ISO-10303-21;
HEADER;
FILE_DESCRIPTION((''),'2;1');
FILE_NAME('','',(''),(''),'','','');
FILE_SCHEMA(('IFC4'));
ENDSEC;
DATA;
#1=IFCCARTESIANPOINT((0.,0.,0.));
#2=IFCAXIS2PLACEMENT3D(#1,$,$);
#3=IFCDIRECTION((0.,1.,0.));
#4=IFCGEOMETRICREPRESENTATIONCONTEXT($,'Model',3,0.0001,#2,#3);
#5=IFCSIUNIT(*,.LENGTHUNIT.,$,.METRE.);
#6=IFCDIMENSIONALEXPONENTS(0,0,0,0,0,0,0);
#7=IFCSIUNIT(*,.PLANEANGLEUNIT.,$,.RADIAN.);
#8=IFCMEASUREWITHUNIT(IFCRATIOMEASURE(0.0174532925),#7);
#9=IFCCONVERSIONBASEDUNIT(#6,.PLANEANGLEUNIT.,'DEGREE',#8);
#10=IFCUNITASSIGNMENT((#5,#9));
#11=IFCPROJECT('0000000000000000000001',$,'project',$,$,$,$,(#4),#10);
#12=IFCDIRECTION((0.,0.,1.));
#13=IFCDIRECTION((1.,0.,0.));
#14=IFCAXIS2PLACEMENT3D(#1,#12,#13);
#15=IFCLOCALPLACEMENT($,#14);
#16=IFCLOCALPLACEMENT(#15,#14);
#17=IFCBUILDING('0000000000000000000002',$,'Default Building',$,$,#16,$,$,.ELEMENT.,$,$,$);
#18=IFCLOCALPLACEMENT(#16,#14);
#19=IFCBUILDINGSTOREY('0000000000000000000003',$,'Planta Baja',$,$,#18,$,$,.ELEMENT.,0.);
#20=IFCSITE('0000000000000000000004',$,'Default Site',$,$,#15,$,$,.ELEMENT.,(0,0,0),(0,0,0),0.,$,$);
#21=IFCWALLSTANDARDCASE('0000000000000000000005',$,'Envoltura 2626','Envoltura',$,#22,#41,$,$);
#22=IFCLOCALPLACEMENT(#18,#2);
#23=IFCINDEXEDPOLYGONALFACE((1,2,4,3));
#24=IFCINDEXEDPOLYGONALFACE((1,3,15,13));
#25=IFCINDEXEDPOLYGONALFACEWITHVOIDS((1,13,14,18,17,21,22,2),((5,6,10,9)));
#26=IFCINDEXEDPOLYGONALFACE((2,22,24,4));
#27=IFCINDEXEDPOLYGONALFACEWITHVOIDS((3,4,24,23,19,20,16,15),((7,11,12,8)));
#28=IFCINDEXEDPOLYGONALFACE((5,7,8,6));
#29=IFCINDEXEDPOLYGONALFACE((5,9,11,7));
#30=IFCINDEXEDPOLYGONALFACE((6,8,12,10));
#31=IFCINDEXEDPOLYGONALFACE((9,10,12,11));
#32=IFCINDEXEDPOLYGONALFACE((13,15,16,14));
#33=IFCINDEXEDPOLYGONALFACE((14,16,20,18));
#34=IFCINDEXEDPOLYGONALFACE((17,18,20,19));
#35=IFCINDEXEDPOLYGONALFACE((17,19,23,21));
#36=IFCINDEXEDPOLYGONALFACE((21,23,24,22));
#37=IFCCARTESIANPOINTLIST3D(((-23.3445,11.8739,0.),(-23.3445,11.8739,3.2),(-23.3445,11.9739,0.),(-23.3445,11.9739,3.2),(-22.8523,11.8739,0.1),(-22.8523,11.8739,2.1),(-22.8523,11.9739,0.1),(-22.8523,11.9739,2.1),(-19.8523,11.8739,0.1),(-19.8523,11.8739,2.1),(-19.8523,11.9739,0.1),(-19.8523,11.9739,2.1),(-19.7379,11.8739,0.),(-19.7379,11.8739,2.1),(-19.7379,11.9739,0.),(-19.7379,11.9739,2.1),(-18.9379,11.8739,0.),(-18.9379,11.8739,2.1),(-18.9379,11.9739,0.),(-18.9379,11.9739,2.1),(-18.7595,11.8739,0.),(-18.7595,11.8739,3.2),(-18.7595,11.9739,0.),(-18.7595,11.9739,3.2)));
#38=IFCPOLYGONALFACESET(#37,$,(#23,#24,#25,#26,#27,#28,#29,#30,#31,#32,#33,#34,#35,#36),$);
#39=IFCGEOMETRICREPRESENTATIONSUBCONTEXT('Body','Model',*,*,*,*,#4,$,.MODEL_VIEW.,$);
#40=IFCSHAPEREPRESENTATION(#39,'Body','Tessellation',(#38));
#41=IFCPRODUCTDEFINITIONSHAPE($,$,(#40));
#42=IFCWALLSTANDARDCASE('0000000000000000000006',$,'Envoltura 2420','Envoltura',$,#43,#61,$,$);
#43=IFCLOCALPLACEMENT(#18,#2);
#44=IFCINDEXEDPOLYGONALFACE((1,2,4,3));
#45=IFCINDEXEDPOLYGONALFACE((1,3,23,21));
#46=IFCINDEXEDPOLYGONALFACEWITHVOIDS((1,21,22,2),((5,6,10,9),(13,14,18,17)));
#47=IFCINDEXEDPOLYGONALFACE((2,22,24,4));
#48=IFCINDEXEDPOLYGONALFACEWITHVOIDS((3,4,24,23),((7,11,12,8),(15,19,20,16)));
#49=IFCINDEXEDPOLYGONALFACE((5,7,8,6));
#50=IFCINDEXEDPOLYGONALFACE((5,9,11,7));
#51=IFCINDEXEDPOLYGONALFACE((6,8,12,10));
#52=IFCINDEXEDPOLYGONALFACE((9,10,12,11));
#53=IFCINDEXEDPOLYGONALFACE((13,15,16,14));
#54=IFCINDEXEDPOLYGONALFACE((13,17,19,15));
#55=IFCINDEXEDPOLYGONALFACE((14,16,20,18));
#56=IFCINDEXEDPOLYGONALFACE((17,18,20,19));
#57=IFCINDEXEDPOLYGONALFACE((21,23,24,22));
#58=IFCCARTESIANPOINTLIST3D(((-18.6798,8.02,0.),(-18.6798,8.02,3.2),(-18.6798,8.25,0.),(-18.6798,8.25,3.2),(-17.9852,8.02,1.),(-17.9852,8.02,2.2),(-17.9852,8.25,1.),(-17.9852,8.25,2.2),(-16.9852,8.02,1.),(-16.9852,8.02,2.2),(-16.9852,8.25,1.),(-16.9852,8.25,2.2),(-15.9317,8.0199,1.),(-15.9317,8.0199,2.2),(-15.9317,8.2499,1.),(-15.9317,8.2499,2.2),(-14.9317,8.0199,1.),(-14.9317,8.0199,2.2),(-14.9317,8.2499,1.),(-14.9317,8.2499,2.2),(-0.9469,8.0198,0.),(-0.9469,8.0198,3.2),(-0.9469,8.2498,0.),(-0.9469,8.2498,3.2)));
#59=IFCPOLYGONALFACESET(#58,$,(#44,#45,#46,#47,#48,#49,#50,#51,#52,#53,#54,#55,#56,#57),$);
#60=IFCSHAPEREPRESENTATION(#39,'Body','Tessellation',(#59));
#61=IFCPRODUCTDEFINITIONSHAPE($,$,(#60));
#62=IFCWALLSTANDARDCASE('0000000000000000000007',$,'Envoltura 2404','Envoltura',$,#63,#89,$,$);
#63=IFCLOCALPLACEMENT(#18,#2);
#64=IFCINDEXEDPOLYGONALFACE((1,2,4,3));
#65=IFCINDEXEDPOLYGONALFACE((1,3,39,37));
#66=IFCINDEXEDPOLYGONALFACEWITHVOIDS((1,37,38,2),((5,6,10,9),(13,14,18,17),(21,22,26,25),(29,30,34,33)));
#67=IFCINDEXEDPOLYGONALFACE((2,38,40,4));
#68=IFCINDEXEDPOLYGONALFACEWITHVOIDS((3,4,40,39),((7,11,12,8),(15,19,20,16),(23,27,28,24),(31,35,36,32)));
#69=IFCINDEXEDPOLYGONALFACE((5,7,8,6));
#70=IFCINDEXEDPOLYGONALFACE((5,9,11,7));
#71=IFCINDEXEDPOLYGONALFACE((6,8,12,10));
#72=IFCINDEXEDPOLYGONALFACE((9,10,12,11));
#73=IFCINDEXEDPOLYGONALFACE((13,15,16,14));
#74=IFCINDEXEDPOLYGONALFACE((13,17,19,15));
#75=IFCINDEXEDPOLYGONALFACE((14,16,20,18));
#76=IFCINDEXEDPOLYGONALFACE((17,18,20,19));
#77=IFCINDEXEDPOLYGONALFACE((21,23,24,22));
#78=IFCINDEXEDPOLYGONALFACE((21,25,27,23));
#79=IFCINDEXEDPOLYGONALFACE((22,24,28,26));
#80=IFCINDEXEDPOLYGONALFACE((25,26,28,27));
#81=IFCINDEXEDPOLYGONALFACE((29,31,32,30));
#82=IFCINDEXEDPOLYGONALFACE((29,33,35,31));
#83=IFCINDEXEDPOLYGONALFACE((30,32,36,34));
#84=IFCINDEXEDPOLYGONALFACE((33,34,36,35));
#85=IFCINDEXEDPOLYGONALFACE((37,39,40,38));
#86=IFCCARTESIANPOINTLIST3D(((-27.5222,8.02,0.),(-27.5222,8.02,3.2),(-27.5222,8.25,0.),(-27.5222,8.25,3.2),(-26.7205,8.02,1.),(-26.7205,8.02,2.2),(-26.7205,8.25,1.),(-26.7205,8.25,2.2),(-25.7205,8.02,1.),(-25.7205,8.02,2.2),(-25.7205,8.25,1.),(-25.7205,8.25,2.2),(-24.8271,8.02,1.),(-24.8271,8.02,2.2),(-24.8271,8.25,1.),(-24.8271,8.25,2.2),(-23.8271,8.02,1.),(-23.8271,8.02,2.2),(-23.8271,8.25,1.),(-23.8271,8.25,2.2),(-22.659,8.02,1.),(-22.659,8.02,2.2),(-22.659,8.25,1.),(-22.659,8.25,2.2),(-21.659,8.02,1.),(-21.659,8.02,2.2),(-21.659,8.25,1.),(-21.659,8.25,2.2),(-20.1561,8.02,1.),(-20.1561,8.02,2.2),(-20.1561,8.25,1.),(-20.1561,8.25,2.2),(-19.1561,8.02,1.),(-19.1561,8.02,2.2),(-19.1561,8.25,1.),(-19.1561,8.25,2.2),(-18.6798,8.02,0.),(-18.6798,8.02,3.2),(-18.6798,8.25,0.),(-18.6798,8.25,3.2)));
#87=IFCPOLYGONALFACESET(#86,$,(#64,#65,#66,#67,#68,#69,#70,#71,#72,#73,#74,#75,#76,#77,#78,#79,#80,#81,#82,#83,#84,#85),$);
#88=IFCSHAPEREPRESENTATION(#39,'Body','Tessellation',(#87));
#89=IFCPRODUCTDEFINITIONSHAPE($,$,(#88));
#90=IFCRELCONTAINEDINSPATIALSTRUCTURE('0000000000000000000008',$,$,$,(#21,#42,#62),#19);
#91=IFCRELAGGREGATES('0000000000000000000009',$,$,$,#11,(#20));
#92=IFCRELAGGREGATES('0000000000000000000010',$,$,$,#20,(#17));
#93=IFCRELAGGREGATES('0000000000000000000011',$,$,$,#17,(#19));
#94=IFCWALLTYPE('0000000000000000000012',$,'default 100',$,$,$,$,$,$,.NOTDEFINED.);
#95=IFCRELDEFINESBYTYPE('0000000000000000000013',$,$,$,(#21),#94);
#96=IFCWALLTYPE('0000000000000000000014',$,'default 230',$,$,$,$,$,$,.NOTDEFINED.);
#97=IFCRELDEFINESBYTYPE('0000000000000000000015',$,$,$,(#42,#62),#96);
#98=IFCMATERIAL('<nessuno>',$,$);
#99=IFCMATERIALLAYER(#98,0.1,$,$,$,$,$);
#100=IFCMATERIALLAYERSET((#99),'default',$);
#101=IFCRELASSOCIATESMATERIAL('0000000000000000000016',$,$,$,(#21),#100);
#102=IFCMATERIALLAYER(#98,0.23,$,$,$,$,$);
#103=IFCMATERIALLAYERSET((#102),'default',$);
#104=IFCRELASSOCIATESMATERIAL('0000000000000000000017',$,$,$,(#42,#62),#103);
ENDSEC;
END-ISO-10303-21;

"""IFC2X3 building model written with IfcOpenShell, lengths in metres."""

from ifc_helpers import new_model, entity, si_unit, converted_unit, direction, frame, origin, origin_with_axes, origin_2d_with_axis, place, context, subcontext, project, spatial, polyline, rectangle, outline, extrude, material, layer, layer_set, layer_usage, type_object, element, save


model = new_model("IFC2X3")

# Units and contexts
model_context = context("Model", 3, precision=0.0001, world=origin(), true_north=direction((0.0, 1.0, 0.0)))
body_context = subcontext(model_context, "Body", "Model", "MODEL_VIEW")
ifc_project = project(units=[si_unit("LENGTHUNIT", "METRE"), converted_unit("PLANEANGLEUNIT", "DEGREE", entity("IfcRatioMeasure", 0.0174532925), si_unit("PLANEANGLEUNIT", "RADIAN"), dimensions=[0, 0, 0, 0, 0, 0, 0])], contexts=[model_context])

# Site, building, storey
site_placement = place(None, origin_with_axes())
site = spatial("IfcSite", under=ifc_project, at=site_placement, Name="Default Site", CompositionType="ELEMENT", RefLatitude=(0, 0, 0), RefLongitude=(0, 0, 0), RefElevation=0.0)
building_placement = place(site_placement, origin_with_axes())
building = spatial("IfcBuilding", under=site, at=building_placement, Name="Default Building", CompositionType="ELEMENT")
storey_placement = place(building_placement, origin_with_axes())
storey = spatial("IfcBuildingStorey", under=building, at=storey_placement, Name="Planta Baja", CompositionType="ELEMENT", Elevation=0.0)

# Shared definitions
ifc_material_1 = material(Name="<nessuno>")

# Shared definitions
ifc_layer_1 = layer(ifc_material_1, 0.1)
ifc_layer_set_1 = layer_set([ifc_layer_1], Name="default")
wall_type_1 = type_object("IfcWallType", Name="default 100", PredefinedType="NOTDEFINED")

# Wall, openings
ifc_layer_usage_1 = layer_usage(ifc_layer_set_1, "AXIS2", "POSITIVE", -0.05)
wall_1_placement = place(storey_placement, frame((-23.3645, 11.9239, 0.0), z_axis=(0.0, 0.0, 1.0), x_axis=(1.0, 0.0, 0.0)))
wall_1 = element("IfcWallStandardCase", 1, at=wall_1_placement, inside=storey, type_object=wall_type_1, material=ifc_layer_usage_1, Name="Envoltura 2626", Description="Envoltura", context=body_context, shape_type="SweptSolid", body=[
    extrude(rectangle(XDim=0.1, YDim=4.585, at=origin_2d_with_axis()), frame((2.3125, 0.0, 0.0), z_axis=(0.0, 0.0, 1.0), x_axis=(0.0, -1.0, 0.0)), (0.0, 0.0, 1.0), 3.2),
])
opening_1_placement = place(wall_1_placement, frame((3.6266, 0.0, 0.0), z_axis=(0.0, 0.0, 1.0), x_axis=(-1.0, 0.0, 0.0)))
element("IfcOpeningElement", 2, at=opening_1_placement, cuts=wall_1, ObjectType="Opening", context=body_context, shape_type="SweptSolid", body=[
    extrude(outline(polyline([(0.0, 2.1), (0.0, 0.0), (0.8, 0.0), (0.8, 2.1), (0.0, 2.1)])), frame((0.0, -0.05, 0.0), z_axis=(0.0, 1.0, 0.0), x_axis=(-1.0, 0.0, 0.0)), (0.0, 0.0, 1.0), 0.1),
])
opening_2_placement = place(wall_1_placement, frame((0.5122, 0.0, 0.0), z_axis=(0.0, 0.0, 1.0), x_axis=(-1.0, 0.0, 0.0)))
element("IfcOpeningElement", 3, at=opening_2_placement, cuts=wall_1, ObjectType="Opening", context=body_context, shape_type="SweptSolid", body=[
    extrude(outline(polyline([(0.0, 2.1), (0.0, 0.1), (3.0, 0.1), (3.0, 2.1), (0.0, 2.1)])), frame((0.0, -0.05, 0.0), z_axis=(0.0, 1.0, 0.0), x_axis=(-1.0, 0.0, 0.0)), (0.0, 0.0, 1.0), 0.1),
])

# Shared definitions
ifc_layer_2 = layer(ifc_material_1, 0.23)
ifc_layer_set_2 = layer_set([ifc_layer_2], Name="default")
wall_type_2 = type_object("IfcWallType", Name="default 230", PredefinedType="NOTDEFINED")

# Walls, openings
ifc_layer_usage_2 = layer_usage(ifc_layer_set_2, "AXIS2", "POSITIVE", -0.115)
wall_2_placement = place(storey_placement, frame((-0.9469, 8.1348, 0.0), z_axis=(0.0, 0.0, 1.0), x_axis=(-1.0, 0.000008, 0.0)))
wall_2 = element("IfcWallStandardCase", 4, at=wall_2_placement, inside=storey, type_object=wall_type_2, material=ifc_layer_usage_2, Name="Envoltura 2420", Description="Envoltura", context=body_context, shape_type="SweptSolid", body=[
    extrude(outline(polyline([(13.3431, 0.115), (0.0, 0.115), (0.0, -0.115), (17.7329, -0.115), (17.7329, 0.115), (13.3431, 0.115)])), origin_with_axes(), (0.0, 0.0, 1.0), 3.2),
])
opening_3_placement = place(wall_2_placement, frame((16.0383, 0.0, 0.0), z_axis=(0.0, 0.0, 1.0), x_axis=(-1.0, 0.0, 0.0)))
element("IfcOpeningElement", 5, at=opening_3_placement, cuts=wall_2, ObjectType="Opening", context=body_context, shape_type="SweptSolid", body=[
    extrude(outline(polyline([(0.0, 2.2), (0.0, 1.0), (1.0, 1.0), (1.0, 2.2), (0.0, 2.2)])), frame((0.0, -0.115, 0.0), z_axis=(0.0, 1.0, 0.0), x_axis=(-1.0, 0.0, 0.0)), (0.0, 0.0, 1.0), 0.23),
])
opening_4_placement = place(wall_2_placement, frame((13.9848, 0.0, 0.0), z_axis=(0.0, 0.0, 1.0), x_axis=(-1.0, 0.0, 0.0)))
element("IfcOpeningElement", 6, at=opening_4_placement, cuts=wall_2, ObjectType="Opening", context=body_context, shape_type="SweptSolid", body=[
    extrude(outline(polyline([(0.0, 2.2), (0.0, 1.0), (1.0, 1.0), (1.0, 2.2), (0.0, 2.2)])), frame((0.0, -0.115, 0.0), z_axis=(0.0, 1.0, 0.0), x_axis=(-1.0, 0.0, 0.0)), (0.0, 0.0, 1.0), 0.23),
])
ifc_layer_usage_3 = layer_usage(ifc_layer_set_2, "AXIS2", "POSITIVE", -0.115)
wall_3_placement = place(storey_placement, frame((-27.5169, 8.135, 0.0), z_axis=(0.0, 0.0, 1.0), x_axis=(1.0, 0.0, 0.0)))
wall_3 = element("IfcWallStandardCase", 7, at=wall_3_placement, inside=storey, type_object=wall_type_2, material=ifc_layer_usage_3, Name="Envoltura 2404", Description="Envoltura", context=body_context, shape_type="SweptSolid", body=[
    extrude(rectangle(XDim=8.8424, YDim=0.23, at=origin_2d_with_axis()), frame((4.4159, 0.0, 0.0), z_axis=(0.0, 0.0, 1.0), x_axis=(1.0, 0.0, 0.0)), (0.0, 0.0, 1.0), 3.2),
])
opening_5_placement = place(wall_3_placement, frame((2.6897, 0.0, 0.0), z_axis=(0.0, 0.0, 1.0), x_axis=(1.0, 0.0, 0.0)))
element("IfcOpeningElement", 8, at=opening_5_placement, cuts=wall_3, ObjectType="Opening", context=body_context, shape_type="SweptSolid", body=[
    extrude(outline(polyline([(0.0, 2.2), (0.0, 1.0), (1.0, 1.0), (1.0, 2.2), (0.0, 2.2)])), frame((0.0, 0.115, 0.0), z_axis=(0.0, -1.0, 0.0), x_axis=(1.0, 0.0, 0.0)), (0.0, 0.0, 1.0), 0.23),
])
opening_6_placement = place(wall_3_placement, frame((7.3607, 0.0, 0.0), z_axis=(0.0, 0.0, 1.0), x_axis=(1.0, 0.0, 0.0)))
element("IfcOpeningElement", 9, at=opening_6_placement, cuts=wall_3, ObjectType="Opening", context=body_context, shape_type="SweptSolid", body=[
    extrude(outline(polyline([(0.0, 2.2), (0.0, 1.0), (1.0, 1.0), (1.0, 2.2), (0.0, 2.2)])), frame((0.0, 0.115, 0.0), z_axis=(0.0, -1.0, 0.0), x_axis=(1.0, 0.0, 0.0)), (0.0, 0.0, 1.0), 0.23),
])
opening_7_placement = place(wall_3_placement, frame((0.7963, 0.0, 0.0), z_axis=(0.0, 0.0, 1.0), x_axis=(1.0, 0.0, 0.0)))
element("IfcOpeningElement", 10, at=opening_7_placement, cuts=wall_3, ObjectType="Opening", context=body_context, shape_type="SweptSolid", body=[
    extrude(outline(polyline([(0.0, 2.2), (0.0, 1.0), (1.0, 1.0), (1.0, 2.2), (0.0, 2.2)])), frame((0.0, 0.115, 0.0), z_axis=(0.0, -1.0, 0.0), x_axis=(1.0, 0.0, 0.0)), (0.0, 0.0, 1.0), 0.23),
])
opening_8_placement = place(wall_3_placement, frame((4.8579, 0.0, 0.0), z_axis=(0.0, 0.0, 1.0), x_axis=(1.0, 0.0, 0.0)))
element("IfcOpeningElement", 11, at=opening_8_placement, cuts=wall_3, ObjectType="Opening", context=body_context, shape_type="SweptSolid", body=[
    extrude(outline(polyline([(0.0, 2.2), (0.0, 1.0), (1.0, 1.0), (1.0, 2.2), (0.0, 2.2)])), frame((0.0, 0.115, 0.0), z_axis=(0.0, -1.0, 0.0), x_axis=(1.0, 0.0, 0.0)), (0.0, 0.0, 1.0), 0.23),
])

save(model, "model.ifc")
